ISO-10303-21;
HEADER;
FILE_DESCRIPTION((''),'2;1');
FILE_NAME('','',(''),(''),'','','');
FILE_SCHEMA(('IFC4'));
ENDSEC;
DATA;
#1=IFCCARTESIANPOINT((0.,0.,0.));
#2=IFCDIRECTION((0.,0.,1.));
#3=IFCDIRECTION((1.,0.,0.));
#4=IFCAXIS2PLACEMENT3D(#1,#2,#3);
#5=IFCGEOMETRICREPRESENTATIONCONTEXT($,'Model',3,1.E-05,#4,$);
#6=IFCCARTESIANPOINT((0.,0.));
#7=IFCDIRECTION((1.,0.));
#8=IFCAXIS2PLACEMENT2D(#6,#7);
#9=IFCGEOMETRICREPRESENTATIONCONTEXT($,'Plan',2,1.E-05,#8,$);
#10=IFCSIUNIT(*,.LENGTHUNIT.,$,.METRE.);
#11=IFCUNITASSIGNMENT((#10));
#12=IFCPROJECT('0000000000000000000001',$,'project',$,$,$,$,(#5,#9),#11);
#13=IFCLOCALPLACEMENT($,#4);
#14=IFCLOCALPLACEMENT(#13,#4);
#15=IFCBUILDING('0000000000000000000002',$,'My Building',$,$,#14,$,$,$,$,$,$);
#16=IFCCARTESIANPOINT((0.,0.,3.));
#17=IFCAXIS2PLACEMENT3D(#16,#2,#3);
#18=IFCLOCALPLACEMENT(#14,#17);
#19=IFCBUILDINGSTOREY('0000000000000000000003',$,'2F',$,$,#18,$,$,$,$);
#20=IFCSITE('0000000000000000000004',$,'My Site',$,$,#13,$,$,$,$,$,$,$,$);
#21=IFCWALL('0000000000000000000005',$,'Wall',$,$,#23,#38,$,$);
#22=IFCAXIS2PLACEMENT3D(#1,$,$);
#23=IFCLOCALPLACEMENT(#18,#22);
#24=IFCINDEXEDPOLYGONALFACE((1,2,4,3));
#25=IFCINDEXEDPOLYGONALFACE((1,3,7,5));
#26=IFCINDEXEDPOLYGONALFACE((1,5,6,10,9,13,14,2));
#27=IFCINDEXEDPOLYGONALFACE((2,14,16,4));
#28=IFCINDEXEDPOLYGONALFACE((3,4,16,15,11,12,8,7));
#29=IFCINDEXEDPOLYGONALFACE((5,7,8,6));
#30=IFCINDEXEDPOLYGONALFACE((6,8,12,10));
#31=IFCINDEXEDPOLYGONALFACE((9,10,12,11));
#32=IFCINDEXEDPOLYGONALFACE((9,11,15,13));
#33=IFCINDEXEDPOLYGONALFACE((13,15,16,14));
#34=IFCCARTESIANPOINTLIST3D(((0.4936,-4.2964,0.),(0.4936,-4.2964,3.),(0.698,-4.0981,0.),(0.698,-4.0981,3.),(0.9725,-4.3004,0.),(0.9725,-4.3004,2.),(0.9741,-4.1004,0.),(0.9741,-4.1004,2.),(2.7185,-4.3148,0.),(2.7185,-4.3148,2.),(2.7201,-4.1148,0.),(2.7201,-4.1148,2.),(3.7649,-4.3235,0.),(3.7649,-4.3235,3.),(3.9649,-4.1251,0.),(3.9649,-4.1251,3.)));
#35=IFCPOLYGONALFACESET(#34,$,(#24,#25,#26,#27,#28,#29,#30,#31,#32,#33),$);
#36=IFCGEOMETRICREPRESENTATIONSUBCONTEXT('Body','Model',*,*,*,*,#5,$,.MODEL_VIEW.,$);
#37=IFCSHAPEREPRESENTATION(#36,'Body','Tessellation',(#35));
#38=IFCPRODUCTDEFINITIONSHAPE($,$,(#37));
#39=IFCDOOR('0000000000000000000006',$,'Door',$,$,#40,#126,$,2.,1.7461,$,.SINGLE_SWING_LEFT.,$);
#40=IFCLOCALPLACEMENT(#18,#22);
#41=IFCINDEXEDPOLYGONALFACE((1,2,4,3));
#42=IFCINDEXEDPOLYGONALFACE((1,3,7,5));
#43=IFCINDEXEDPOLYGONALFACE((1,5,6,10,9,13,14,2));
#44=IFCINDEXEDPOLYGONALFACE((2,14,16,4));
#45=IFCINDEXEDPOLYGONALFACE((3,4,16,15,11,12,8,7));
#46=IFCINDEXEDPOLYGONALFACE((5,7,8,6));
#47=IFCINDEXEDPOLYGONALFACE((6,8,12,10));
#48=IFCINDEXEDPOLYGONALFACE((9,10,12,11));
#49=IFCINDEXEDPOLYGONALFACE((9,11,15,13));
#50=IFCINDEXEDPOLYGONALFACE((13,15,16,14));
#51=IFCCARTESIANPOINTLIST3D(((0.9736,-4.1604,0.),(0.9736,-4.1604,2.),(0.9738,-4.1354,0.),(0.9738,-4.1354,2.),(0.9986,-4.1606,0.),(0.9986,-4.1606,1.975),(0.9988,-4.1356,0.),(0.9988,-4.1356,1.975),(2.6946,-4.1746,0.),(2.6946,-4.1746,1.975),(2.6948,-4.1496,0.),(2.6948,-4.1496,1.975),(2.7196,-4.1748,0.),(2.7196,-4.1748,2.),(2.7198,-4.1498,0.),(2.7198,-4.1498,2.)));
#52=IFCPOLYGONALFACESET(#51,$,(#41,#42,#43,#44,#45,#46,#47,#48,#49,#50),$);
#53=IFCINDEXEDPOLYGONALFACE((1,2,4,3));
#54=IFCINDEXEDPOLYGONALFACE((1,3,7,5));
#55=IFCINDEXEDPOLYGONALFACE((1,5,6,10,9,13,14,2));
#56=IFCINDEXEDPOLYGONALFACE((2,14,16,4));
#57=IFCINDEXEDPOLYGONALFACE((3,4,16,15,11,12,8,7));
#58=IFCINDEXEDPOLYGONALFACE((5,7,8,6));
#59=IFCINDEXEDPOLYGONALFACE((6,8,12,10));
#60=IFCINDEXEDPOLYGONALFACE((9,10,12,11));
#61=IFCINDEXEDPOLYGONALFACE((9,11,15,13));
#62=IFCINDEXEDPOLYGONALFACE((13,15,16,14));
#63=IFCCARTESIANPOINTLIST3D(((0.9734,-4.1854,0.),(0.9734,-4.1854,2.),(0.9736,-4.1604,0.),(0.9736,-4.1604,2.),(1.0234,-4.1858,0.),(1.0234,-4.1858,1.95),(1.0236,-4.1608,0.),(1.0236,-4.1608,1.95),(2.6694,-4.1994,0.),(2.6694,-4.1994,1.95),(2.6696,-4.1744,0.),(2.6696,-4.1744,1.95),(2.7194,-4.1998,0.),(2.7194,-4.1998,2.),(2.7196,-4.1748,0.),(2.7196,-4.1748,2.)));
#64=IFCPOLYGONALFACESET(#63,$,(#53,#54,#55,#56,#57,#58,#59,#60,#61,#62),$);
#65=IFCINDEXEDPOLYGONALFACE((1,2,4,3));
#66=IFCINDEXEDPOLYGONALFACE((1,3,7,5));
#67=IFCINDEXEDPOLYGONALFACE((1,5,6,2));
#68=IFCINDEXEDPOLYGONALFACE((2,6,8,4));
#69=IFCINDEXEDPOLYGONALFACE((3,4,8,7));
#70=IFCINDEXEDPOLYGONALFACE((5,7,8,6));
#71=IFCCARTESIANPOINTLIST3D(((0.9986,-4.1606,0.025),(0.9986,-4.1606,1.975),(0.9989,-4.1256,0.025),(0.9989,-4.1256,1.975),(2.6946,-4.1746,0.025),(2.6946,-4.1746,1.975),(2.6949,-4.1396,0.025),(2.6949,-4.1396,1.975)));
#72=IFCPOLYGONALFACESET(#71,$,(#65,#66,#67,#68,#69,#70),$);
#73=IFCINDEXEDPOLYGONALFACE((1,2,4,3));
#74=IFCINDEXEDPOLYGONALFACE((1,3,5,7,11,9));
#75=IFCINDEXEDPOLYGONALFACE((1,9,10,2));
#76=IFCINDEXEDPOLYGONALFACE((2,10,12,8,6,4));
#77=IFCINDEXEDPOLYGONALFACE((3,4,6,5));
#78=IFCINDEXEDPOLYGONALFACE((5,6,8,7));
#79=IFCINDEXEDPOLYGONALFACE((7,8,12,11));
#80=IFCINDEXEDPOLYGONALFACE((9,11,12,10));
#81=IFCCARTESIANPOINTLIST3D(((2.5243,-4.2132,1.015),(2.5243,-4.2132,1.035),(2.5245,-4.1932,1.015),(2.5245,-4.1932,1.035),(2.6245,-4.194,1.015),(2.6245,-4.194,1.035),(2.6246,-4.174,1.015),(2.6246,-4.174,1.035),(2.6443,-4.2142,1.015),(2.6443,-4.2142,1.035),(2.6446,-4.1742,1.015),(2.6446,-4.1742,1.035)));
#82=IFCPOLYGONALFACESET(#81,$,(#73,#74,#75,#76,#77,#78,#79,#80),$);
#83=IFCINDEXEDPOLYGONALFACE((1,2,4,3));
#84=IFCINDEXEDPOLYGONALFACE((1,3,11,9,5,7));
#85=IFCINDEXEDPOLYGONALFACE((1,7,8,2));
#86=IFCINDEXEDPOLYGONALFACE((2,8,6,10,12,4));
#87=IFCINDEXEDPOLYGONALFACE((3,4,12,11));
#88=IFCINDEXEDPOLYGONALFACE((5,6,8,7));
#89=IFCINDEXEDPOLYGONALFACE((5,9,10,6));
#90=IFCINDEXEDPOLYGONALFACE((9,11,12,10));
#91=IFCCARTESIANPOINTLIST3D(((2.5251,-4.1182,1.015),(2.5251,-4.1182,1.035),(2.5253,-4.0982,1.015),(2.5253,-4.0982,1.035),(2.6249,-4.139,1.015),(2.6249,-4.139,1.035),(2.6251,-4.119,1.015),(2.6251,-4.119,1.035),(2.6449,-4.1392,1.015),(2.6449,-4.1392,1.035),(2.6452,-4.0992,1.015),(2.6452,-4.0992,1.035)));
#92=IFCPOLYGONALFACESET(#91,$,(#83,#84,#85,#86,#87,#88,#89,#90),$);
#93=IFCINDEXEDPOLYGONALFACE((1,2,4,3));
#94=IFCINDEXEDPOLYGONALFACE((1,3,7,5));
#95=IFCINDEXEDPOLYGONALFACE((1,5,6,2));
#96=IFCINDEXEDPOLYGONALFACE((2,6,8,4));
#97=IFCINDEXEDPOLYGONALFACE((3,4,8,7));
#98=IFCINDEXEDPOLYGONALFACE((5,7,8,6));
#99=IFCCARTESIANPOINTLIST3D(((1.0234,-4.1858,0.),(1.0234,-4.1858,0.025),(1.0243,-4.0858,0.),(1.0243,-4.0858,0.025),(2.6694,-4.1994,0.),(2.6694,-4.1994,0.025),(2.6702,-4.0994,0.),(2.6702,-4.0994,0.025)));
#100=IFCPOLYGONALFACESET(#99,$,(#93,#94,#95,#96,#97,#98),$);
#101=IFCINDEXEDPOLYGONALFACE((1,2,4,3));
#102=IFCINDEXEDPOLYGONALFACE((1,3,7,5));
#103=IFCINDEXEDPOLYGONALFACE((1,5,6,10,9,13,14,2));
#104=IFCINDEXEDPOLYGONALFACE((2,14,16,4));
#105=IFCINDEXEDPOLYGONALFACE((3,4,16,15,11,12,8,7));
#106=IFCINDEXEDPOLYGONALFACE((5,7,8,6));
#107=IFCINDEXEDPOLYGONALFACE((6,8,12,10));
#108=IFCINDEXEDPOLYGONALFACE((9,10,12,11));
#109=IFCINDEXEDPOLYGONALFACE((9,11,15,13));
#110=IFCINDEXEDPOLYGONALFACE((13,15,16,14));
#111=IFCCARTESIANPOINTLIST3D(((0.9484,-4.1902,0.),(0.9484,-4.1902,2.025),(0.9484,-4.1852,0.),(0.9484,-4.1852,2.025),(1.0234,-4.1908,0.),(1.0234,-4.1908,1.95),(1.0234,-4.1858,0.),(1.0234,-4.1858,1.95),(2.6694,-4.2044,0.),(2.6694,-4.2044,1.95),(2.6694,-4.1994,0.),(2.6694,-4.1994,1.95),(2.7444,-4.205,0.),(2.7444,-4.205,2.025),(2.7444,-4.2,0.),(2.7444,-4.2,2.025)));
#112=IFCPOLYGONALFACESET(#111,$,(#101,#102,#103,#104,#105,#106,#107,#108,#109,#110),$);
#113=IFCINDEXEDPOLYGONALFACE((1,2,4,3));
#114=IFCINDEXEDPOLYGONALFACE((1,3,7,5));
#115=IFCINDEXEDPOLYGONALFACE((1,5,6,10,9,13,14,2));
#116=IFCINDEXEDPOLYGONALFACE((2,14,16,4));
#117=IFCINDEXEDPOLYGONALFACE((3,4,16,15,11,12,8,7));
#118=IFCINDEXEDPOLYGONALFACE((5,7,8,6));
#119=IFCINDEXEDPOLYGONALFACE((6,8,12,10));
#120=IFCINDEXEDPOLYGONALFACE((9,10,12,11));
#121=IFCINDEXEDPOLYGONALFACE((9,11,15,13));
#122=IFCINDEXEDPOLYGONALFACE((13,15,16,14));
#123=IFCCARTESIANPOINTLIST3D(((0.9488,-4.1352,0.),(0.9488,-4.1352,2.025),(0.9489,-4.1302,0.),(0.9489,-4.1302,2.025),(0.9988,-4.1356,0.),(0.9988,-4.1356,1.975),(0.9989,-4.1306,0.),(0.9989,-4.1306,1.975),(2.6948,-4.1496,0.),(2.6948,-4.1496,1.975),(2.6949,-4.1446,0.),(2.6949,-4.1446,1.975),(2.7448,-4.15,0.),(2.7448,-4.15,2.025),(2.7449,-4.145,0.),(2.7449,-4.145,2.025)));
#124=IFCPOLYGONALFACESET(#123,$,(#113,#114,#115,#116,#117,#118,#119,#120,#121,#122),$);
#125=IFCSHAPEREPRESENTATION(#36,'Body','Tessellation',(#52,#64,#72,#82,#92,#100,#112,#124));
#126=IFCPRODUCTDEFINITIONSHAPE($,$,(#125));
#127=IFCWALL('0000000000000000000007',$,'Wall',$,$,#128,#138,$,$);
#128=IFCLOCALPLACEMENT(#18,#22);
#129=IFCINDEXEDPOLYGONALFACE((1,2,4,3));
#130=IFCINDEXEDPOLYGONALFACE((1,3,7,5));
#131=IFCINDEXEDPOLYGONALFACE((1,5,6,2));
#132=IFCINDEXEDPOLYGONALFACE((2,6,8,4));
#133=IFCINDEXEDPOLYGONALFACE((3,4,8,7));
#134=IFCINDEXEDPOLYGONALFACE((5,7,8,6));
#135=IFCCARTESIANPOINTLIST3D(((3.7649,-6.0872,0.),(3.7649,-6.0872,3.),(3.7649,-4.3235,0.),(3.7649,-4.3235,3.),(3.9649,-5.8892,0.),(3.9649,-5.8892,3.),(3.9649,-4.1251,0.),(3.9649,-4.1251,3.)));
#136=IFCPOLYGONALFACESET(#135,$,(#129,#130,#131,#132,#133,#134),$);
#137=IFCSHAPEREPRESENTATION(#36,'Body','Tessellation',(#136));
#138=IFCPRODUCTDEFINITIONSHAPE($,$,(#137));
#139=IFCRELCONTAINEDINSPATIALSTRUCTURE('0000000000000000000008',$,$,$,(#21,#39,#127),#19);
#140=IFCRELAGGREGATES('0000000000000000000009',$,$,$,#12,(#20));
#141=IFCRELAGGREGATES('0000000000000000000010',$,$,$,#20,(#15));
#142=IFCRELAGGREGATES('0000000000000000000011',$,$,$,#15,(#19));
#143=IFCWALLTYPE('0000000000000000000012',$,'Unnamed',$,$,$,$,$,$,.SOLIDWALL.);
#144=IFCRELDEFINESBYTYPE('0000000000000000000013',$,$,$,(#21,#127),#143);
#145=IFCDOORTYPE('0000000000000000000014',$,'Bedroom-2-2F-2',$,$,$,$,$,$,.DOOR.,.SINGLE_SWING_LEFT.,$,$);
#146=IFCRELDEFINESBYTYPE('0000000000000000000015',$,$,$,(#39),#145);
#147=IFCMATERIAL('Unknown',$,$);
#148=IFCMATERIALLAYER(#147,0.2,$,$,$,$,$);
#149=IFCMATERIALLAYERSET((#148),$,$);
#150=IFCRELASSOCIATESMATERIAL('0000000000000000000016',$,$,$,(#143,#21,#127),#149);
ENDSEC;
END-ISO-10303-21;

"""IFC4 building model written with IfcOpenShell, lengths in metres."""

from ifc_helpers import new_model, entity, si_unit, frame, origin_with_axes, origin_2d_with_axis, place, context, subcontext, project, spatial, line, indexed_curve, outline, extrude, shape, source, transform, mapped, material, layer, layer_set, layer_usage, type_object, type_shapes, element, fill, save


model = new_model("IFC4")

# Units and contexts
model_context = context("Model", 3, precision=1e-05, world=origin_with_axes())
plan_context = context("Plan", 2, precision=1e-05, world=origin_2d_with_axis())
body_context_1 = subcontext(model_context, "Body", "Model", "MODEL_VIEW")
body_context_2 = subcontext(plan_context, "Body", "Plan", "PLAN_VIEW")
ifc_project = project(units=[si_unit("LENGTHUNIT", "METRE")], contexts=[model_context, plan_context])

# Site, building, storey
site_placement = place(None, origin_with_axes())
site = spatial("IfcSite", under=ifc_project, at=site_placement, Name="My Site")
building_placement = place(site_placement, origin_with_axes())
building = spatial("IfcBuilding", under=site, at=building_placement, Name="My Building")
storey_placement = place(building_placement, frame((0.0, 0.0, 3.0), z_axis=(0.0, 0.0, 1.0), x_axis=(1.0, 0.0, 0.0)))
storey = spatial("IfcBuildingStorey", under=building, at=storey_placement, Name="2F")

# Shared definitions
ifc_material = material(Name="Unknown")

# Shared definitions
ifc_layer_1 = layer(ifc_material, 0.2)
ifc_layer_set_1 = layer_set([ifc_layer_1])
wall_type = type_object("IfcWallType", Name="Unnamed", PredefinedType="SOLIDWALL", material=ifc_layer_set_1)

# Wall, opening, door
ifc_layer_usage_1 = layer_usage(ifc_layer_set_1, "AXIS2", "POSITIVE", 0.0)
wall_1_placement = place(storey_placement, frame((0.4936, -4.2964, 0.0), z_axis=(0.0, 0.0, 1.0), x_axis=(0.999966, -0.008264, 0.0)))
wall_1 = element("IfcWall", 1, at=wall_1_placement, inside=storey, type_object=wall_type, material=ifc_layer_usage_1, Name="Wall", context=body_context_1, shape_type="SweptSolid", body=[
    extrude(outline(indexed_curve([(0.0, 0.0), (0.2027, 0.2), (3.4697, 0.2), (3.2714, 0.0)], segments=[line(1, 2, 3, 4, 1)])), origin_with_axes(), (0.0, 0.0, 1.0), 3.0),
])
shared_shape_1 = source(origin_with_axes(), body_context_1, "Body", "SweptSolid", [
    extrude(outline(indexed_curve([(0.0, 0.0), (1.7461, 0.0), (1.7461, 2.0), (0.0, 2.0)], segments=[line(1, 2, 3, 4, 1)])), frame((0.0, -0.6, 0.0), z_axis=(0.0, -1.0, 0.0), x_axis=(1.0, 0.0, 0.0)), (0.0, 0.0, -1.0), 1.2),
])
opening_1_placement = place(wall_1_placement, frame((0.4789, 0.115, 0.0), z_axis=(0.0, 0.0, 1.0), x_axis=(1.0, 0.0, 0.0)))
opening_1 = element("IfcOpeningElement", 2, at=opening_1_placement, cuts=wall_1, PredefinedType="OPENING", context=body_context_1, shape_type="MappedRepresentation", body=[
    mapped(shared_shape_1, transform((0.0, 0.0, 0.0), x_axis=(1.0, 0.0, 0.0), y_axis=(0.0, 1.0, 0.0), z_axis=(0.0, 0.0, 1.0), scale=1.0)),
])
door_type_1 = type_object("IfcDoorType", Name="Bedroom-2-2F-2", OperationType="SINGLE_SWING_LEFT", PredefinedType="DOOR")
shared_shape_2 = source(origin_with_axes(), body_context_1, "Body", "SweptSolid", [
    extrude(outline(indexed_curve([(0.0, 0.0), (0.0, 2.0), (1.7461, 2.0), (1.7461, 0.0), (1.7211, 0.0), (1.7211, 1.975), (0.025, 1.975), (0.025, 0.0)], segments=[line(1, 2, 3, 4, 5, 6, 7, 8, 1)])), frame((0.0, 0.025, 0.0), z_axis=(0.0, -1.0, 0.0), x_axis=(1.0, 0.0, 0.0)), (0.0, 0.0, -1.0), 0.025),
    extrude(outline(indexed_curve([(0.0, 0.0), (0.0, 2.0), (1.7461, 2.0), (1.7461, 0.0), (1.6961, 0.0), (1.6961, 1.95), (0.05, 1.95), (0.05, 0.0)], segments=[line(1, 2, 3, 4, 5, 6, 7, 8, 1)])), frame((0.0, 0.0, 0.0), z_axis=(0.0, -1.0, 0.0), x_axis=(1.0, 0.0, 0.0)), (0.0, 0.0, -1.0), 0.025),
    extrude(outline(indexed_curve([(0.0, 0.0), (1.6961, 0.0), (1.6961, 0.035), (0.0, 0.035)], segments=[line(1, 2, 3, 4, 1)])), frame((0.025, 0.025, 0.025), z_axis=(0.0, 0.0, 1.0), x_axis=(1.0, 0.0, 0.0)), (0.0, 0.0, 1.0), 1.95),
    extrude(outline(indexed_curve([(0.0, 0.0), (0.0, -0.04), (-0.12, -0.04), (-0.12, -0.02), (-0.02, -0.02), (-0.02, 0.0)], segments=[line(1, 2, 3, 4, 5, 6, 1)])), frame((1.6711, 0.025, 1.015), z_axis=(0.0, 0.0, 1.0), x_axis=(1.0, 0.0, 0.0)), (0.0, 0.0, 1.0), 0.02),
    extrude(outline(indexed_curve([(0.0, 0.0), (0.0, 0.04), (-0.12, 0.04), (-0.12, 0.02), (-0.02, 0.02), (-0.02, 0.0)], segments=[line(1, 2, 3, 4, 5, 6, 1)])), frame((1.6711, 0.06, 1.015), z_axis=(0.0, 0.0, 1.0), x_axis=(1.0, 0.0, 0.0)), (0.0, 0.0, 1.0), 0.02),
    extrude(outline(indexed_curve([(0.0, 0.0), (1.6461, 0.0), (1.6461, 0.1), (0.0, 0.1)], segments=[line(1, 2, 3, 4, 1)])), frame((0.05, 0.0, 0.0), z_axis=(0.0, 0.0, 1.0), x_axis=(1.0, 0.0, 0.0)), (0.0, 0.0, 1.0), 0.025),
    extrude(outline(indexed_curve([(0.0, 0.0), (0.0, 2.025), (1.7961, 2.025), (1.7961, 0.0), (1.7211, 0.0), (1.7211, 1.95), (0.075, 1.95), (0.075, 0.0)], segments=[line(1, 2, 3, 4, 5, 6, 7, 8, 1)])), frame((-0.025, -0.005, 0.0), z_axis=(0.0, -1.0, 0.0), x_axis=(1.0, 0.0, 0.0)), (0.0, 0.0, -1.0), 0.005),
    extrude(outline(indexed_curve([(0.0, 0.0), (0.0, 2.025), (1.7961, 2.025), (1.7961, 0.0), (1.7461, 0.0), (1.7461, 1.975), (0.05, 1.975), (0.05, 0.0)], segments=[line(1, 2, 3, 4, 5, 6, 7, 8, 1)])), frame((-0.025, 0.05, 0.0), z_axis=(0.0, -1.0, 0.0), x_axis=(1.0, 0.0, 0.0)), (0.0, 0.0, -1.0), 0.005),
])
shared_shape_3 = source(origin_with_axes(), body_context_2, "Body", "Curve2D", [
    entity("IfcIndexedPolyCurve", entity("IfcCartesianPointList2D", [[0.0, 0.0], [0.0, 0.05], [0.025, 0.05], [0.025, 0.025], [0.05, 0.025], [0.05, 0.0]]), [entity("IfcLineIndex", [1, 2, 3, 4, 5, 6, 1])]),
    entity("IfcIndexedPolyCurve", entity("IfcCartesianPointList2D", [[1.7461, 0.0], [1.7461, 0.05], [1.7211, 0.05], [1.7211, 0.025], [1.6961, 0.025], [1.6961, 0.0]]), [entity("IfcLineIndex", [1, 2, 3, 4, 5, 6, 1])]),
    entity("IfcTrimmedCurve", entity("IfcEllipse", entity("IfcAxis2Placement2D", entity("IfcCartesianPoint", [0.06, 0.05]), entity("IfcDirection", [1.0, 0.0])), 1.6611, 1.6961), [entity("IfcCartesianPoint", [1.7211, 0.05])], [entity("IfcCartesianPoint", [0.06, 1.7461])], True, "CARTESIAN"),
    entity("IfcIndexedPolyCurve", entity("IfcCartesianPointList2D", [[0.025, 0.05], [0.06, 0.05], [0.06, 1.7461], [0.025, 1.7461]]), [entity("IfcLineIndex", [1, 2, 3, 4, 1])]),
])
type_shapes(door_type_1, [shared_shape_2, shared_shape_3])
door_1_placement = place(opening_1_placement, frame((0.0, 0.0, 0.0), z_axis=(0.0, 0.0, 1.0), x_axis=(1.0, 0.0, 0.0)))
door_1 = element("IfcDoor", 3, at=door_1_placement, inside=storey, type_object=door_type_1, Name="Door", OperationType="SINGLE_SWING_LEFT", OverallHeight=2.0, OverallWidth=1.7461, shapes=[
    shape(body_context_1, "Body", "MappedRepresentation", [mapped(shared_shape_2, transform((0.0, 0.0, 0.0), x_axis=(1.0, 0.0, 0.0), y_axis=(0.0, 1.0, 0.0), z_axis=(0.0, 0.0, 1.0), scale=1.0))]),
    shape(body_context_2, "Body", "MappedRepresentation", [mapped(shared_shape_3, transform((0.0, 0.0, 0.0), x_axis=(1.0, 0.0, 0.0), y_axis=(0.0, 1.0, 0.0), z_axis=(0.0, 0.0, 1.0), scale=1.0))]),
])
fill(opening_1, door_1)

# Wall
ifc_layer_usage_2 = layer_usage(ifc_layer_set_1, "AXIS2", "POSITIVE", 0.0)
wall_2_placement = place(storey_placement, frame((3.7649, -4.3235, 0.0), z_axis=(0.0, 0.0, 1.0), x_axis=(0.0, -1.0, 0.0)))
element("IfcWall", 4, at=wall_2_placement, inside=storey, type_object=wall_type, material=ifc_layer_usage_2, Name="Wall", context=body_context_1, shape_type="SweptSolid", body=[
    extrude(outline(indexed_curve([(0.0, 0.0), (-0.1984, 0.2), (1.5658, 0.2), (1.7637, 0.0)], segments=[line(1, 2, 3, 4, 1)])), origin_with_axes(), (0.0, 0.0, 1.0), 3.0),
])

save(model, "model.ifc")
